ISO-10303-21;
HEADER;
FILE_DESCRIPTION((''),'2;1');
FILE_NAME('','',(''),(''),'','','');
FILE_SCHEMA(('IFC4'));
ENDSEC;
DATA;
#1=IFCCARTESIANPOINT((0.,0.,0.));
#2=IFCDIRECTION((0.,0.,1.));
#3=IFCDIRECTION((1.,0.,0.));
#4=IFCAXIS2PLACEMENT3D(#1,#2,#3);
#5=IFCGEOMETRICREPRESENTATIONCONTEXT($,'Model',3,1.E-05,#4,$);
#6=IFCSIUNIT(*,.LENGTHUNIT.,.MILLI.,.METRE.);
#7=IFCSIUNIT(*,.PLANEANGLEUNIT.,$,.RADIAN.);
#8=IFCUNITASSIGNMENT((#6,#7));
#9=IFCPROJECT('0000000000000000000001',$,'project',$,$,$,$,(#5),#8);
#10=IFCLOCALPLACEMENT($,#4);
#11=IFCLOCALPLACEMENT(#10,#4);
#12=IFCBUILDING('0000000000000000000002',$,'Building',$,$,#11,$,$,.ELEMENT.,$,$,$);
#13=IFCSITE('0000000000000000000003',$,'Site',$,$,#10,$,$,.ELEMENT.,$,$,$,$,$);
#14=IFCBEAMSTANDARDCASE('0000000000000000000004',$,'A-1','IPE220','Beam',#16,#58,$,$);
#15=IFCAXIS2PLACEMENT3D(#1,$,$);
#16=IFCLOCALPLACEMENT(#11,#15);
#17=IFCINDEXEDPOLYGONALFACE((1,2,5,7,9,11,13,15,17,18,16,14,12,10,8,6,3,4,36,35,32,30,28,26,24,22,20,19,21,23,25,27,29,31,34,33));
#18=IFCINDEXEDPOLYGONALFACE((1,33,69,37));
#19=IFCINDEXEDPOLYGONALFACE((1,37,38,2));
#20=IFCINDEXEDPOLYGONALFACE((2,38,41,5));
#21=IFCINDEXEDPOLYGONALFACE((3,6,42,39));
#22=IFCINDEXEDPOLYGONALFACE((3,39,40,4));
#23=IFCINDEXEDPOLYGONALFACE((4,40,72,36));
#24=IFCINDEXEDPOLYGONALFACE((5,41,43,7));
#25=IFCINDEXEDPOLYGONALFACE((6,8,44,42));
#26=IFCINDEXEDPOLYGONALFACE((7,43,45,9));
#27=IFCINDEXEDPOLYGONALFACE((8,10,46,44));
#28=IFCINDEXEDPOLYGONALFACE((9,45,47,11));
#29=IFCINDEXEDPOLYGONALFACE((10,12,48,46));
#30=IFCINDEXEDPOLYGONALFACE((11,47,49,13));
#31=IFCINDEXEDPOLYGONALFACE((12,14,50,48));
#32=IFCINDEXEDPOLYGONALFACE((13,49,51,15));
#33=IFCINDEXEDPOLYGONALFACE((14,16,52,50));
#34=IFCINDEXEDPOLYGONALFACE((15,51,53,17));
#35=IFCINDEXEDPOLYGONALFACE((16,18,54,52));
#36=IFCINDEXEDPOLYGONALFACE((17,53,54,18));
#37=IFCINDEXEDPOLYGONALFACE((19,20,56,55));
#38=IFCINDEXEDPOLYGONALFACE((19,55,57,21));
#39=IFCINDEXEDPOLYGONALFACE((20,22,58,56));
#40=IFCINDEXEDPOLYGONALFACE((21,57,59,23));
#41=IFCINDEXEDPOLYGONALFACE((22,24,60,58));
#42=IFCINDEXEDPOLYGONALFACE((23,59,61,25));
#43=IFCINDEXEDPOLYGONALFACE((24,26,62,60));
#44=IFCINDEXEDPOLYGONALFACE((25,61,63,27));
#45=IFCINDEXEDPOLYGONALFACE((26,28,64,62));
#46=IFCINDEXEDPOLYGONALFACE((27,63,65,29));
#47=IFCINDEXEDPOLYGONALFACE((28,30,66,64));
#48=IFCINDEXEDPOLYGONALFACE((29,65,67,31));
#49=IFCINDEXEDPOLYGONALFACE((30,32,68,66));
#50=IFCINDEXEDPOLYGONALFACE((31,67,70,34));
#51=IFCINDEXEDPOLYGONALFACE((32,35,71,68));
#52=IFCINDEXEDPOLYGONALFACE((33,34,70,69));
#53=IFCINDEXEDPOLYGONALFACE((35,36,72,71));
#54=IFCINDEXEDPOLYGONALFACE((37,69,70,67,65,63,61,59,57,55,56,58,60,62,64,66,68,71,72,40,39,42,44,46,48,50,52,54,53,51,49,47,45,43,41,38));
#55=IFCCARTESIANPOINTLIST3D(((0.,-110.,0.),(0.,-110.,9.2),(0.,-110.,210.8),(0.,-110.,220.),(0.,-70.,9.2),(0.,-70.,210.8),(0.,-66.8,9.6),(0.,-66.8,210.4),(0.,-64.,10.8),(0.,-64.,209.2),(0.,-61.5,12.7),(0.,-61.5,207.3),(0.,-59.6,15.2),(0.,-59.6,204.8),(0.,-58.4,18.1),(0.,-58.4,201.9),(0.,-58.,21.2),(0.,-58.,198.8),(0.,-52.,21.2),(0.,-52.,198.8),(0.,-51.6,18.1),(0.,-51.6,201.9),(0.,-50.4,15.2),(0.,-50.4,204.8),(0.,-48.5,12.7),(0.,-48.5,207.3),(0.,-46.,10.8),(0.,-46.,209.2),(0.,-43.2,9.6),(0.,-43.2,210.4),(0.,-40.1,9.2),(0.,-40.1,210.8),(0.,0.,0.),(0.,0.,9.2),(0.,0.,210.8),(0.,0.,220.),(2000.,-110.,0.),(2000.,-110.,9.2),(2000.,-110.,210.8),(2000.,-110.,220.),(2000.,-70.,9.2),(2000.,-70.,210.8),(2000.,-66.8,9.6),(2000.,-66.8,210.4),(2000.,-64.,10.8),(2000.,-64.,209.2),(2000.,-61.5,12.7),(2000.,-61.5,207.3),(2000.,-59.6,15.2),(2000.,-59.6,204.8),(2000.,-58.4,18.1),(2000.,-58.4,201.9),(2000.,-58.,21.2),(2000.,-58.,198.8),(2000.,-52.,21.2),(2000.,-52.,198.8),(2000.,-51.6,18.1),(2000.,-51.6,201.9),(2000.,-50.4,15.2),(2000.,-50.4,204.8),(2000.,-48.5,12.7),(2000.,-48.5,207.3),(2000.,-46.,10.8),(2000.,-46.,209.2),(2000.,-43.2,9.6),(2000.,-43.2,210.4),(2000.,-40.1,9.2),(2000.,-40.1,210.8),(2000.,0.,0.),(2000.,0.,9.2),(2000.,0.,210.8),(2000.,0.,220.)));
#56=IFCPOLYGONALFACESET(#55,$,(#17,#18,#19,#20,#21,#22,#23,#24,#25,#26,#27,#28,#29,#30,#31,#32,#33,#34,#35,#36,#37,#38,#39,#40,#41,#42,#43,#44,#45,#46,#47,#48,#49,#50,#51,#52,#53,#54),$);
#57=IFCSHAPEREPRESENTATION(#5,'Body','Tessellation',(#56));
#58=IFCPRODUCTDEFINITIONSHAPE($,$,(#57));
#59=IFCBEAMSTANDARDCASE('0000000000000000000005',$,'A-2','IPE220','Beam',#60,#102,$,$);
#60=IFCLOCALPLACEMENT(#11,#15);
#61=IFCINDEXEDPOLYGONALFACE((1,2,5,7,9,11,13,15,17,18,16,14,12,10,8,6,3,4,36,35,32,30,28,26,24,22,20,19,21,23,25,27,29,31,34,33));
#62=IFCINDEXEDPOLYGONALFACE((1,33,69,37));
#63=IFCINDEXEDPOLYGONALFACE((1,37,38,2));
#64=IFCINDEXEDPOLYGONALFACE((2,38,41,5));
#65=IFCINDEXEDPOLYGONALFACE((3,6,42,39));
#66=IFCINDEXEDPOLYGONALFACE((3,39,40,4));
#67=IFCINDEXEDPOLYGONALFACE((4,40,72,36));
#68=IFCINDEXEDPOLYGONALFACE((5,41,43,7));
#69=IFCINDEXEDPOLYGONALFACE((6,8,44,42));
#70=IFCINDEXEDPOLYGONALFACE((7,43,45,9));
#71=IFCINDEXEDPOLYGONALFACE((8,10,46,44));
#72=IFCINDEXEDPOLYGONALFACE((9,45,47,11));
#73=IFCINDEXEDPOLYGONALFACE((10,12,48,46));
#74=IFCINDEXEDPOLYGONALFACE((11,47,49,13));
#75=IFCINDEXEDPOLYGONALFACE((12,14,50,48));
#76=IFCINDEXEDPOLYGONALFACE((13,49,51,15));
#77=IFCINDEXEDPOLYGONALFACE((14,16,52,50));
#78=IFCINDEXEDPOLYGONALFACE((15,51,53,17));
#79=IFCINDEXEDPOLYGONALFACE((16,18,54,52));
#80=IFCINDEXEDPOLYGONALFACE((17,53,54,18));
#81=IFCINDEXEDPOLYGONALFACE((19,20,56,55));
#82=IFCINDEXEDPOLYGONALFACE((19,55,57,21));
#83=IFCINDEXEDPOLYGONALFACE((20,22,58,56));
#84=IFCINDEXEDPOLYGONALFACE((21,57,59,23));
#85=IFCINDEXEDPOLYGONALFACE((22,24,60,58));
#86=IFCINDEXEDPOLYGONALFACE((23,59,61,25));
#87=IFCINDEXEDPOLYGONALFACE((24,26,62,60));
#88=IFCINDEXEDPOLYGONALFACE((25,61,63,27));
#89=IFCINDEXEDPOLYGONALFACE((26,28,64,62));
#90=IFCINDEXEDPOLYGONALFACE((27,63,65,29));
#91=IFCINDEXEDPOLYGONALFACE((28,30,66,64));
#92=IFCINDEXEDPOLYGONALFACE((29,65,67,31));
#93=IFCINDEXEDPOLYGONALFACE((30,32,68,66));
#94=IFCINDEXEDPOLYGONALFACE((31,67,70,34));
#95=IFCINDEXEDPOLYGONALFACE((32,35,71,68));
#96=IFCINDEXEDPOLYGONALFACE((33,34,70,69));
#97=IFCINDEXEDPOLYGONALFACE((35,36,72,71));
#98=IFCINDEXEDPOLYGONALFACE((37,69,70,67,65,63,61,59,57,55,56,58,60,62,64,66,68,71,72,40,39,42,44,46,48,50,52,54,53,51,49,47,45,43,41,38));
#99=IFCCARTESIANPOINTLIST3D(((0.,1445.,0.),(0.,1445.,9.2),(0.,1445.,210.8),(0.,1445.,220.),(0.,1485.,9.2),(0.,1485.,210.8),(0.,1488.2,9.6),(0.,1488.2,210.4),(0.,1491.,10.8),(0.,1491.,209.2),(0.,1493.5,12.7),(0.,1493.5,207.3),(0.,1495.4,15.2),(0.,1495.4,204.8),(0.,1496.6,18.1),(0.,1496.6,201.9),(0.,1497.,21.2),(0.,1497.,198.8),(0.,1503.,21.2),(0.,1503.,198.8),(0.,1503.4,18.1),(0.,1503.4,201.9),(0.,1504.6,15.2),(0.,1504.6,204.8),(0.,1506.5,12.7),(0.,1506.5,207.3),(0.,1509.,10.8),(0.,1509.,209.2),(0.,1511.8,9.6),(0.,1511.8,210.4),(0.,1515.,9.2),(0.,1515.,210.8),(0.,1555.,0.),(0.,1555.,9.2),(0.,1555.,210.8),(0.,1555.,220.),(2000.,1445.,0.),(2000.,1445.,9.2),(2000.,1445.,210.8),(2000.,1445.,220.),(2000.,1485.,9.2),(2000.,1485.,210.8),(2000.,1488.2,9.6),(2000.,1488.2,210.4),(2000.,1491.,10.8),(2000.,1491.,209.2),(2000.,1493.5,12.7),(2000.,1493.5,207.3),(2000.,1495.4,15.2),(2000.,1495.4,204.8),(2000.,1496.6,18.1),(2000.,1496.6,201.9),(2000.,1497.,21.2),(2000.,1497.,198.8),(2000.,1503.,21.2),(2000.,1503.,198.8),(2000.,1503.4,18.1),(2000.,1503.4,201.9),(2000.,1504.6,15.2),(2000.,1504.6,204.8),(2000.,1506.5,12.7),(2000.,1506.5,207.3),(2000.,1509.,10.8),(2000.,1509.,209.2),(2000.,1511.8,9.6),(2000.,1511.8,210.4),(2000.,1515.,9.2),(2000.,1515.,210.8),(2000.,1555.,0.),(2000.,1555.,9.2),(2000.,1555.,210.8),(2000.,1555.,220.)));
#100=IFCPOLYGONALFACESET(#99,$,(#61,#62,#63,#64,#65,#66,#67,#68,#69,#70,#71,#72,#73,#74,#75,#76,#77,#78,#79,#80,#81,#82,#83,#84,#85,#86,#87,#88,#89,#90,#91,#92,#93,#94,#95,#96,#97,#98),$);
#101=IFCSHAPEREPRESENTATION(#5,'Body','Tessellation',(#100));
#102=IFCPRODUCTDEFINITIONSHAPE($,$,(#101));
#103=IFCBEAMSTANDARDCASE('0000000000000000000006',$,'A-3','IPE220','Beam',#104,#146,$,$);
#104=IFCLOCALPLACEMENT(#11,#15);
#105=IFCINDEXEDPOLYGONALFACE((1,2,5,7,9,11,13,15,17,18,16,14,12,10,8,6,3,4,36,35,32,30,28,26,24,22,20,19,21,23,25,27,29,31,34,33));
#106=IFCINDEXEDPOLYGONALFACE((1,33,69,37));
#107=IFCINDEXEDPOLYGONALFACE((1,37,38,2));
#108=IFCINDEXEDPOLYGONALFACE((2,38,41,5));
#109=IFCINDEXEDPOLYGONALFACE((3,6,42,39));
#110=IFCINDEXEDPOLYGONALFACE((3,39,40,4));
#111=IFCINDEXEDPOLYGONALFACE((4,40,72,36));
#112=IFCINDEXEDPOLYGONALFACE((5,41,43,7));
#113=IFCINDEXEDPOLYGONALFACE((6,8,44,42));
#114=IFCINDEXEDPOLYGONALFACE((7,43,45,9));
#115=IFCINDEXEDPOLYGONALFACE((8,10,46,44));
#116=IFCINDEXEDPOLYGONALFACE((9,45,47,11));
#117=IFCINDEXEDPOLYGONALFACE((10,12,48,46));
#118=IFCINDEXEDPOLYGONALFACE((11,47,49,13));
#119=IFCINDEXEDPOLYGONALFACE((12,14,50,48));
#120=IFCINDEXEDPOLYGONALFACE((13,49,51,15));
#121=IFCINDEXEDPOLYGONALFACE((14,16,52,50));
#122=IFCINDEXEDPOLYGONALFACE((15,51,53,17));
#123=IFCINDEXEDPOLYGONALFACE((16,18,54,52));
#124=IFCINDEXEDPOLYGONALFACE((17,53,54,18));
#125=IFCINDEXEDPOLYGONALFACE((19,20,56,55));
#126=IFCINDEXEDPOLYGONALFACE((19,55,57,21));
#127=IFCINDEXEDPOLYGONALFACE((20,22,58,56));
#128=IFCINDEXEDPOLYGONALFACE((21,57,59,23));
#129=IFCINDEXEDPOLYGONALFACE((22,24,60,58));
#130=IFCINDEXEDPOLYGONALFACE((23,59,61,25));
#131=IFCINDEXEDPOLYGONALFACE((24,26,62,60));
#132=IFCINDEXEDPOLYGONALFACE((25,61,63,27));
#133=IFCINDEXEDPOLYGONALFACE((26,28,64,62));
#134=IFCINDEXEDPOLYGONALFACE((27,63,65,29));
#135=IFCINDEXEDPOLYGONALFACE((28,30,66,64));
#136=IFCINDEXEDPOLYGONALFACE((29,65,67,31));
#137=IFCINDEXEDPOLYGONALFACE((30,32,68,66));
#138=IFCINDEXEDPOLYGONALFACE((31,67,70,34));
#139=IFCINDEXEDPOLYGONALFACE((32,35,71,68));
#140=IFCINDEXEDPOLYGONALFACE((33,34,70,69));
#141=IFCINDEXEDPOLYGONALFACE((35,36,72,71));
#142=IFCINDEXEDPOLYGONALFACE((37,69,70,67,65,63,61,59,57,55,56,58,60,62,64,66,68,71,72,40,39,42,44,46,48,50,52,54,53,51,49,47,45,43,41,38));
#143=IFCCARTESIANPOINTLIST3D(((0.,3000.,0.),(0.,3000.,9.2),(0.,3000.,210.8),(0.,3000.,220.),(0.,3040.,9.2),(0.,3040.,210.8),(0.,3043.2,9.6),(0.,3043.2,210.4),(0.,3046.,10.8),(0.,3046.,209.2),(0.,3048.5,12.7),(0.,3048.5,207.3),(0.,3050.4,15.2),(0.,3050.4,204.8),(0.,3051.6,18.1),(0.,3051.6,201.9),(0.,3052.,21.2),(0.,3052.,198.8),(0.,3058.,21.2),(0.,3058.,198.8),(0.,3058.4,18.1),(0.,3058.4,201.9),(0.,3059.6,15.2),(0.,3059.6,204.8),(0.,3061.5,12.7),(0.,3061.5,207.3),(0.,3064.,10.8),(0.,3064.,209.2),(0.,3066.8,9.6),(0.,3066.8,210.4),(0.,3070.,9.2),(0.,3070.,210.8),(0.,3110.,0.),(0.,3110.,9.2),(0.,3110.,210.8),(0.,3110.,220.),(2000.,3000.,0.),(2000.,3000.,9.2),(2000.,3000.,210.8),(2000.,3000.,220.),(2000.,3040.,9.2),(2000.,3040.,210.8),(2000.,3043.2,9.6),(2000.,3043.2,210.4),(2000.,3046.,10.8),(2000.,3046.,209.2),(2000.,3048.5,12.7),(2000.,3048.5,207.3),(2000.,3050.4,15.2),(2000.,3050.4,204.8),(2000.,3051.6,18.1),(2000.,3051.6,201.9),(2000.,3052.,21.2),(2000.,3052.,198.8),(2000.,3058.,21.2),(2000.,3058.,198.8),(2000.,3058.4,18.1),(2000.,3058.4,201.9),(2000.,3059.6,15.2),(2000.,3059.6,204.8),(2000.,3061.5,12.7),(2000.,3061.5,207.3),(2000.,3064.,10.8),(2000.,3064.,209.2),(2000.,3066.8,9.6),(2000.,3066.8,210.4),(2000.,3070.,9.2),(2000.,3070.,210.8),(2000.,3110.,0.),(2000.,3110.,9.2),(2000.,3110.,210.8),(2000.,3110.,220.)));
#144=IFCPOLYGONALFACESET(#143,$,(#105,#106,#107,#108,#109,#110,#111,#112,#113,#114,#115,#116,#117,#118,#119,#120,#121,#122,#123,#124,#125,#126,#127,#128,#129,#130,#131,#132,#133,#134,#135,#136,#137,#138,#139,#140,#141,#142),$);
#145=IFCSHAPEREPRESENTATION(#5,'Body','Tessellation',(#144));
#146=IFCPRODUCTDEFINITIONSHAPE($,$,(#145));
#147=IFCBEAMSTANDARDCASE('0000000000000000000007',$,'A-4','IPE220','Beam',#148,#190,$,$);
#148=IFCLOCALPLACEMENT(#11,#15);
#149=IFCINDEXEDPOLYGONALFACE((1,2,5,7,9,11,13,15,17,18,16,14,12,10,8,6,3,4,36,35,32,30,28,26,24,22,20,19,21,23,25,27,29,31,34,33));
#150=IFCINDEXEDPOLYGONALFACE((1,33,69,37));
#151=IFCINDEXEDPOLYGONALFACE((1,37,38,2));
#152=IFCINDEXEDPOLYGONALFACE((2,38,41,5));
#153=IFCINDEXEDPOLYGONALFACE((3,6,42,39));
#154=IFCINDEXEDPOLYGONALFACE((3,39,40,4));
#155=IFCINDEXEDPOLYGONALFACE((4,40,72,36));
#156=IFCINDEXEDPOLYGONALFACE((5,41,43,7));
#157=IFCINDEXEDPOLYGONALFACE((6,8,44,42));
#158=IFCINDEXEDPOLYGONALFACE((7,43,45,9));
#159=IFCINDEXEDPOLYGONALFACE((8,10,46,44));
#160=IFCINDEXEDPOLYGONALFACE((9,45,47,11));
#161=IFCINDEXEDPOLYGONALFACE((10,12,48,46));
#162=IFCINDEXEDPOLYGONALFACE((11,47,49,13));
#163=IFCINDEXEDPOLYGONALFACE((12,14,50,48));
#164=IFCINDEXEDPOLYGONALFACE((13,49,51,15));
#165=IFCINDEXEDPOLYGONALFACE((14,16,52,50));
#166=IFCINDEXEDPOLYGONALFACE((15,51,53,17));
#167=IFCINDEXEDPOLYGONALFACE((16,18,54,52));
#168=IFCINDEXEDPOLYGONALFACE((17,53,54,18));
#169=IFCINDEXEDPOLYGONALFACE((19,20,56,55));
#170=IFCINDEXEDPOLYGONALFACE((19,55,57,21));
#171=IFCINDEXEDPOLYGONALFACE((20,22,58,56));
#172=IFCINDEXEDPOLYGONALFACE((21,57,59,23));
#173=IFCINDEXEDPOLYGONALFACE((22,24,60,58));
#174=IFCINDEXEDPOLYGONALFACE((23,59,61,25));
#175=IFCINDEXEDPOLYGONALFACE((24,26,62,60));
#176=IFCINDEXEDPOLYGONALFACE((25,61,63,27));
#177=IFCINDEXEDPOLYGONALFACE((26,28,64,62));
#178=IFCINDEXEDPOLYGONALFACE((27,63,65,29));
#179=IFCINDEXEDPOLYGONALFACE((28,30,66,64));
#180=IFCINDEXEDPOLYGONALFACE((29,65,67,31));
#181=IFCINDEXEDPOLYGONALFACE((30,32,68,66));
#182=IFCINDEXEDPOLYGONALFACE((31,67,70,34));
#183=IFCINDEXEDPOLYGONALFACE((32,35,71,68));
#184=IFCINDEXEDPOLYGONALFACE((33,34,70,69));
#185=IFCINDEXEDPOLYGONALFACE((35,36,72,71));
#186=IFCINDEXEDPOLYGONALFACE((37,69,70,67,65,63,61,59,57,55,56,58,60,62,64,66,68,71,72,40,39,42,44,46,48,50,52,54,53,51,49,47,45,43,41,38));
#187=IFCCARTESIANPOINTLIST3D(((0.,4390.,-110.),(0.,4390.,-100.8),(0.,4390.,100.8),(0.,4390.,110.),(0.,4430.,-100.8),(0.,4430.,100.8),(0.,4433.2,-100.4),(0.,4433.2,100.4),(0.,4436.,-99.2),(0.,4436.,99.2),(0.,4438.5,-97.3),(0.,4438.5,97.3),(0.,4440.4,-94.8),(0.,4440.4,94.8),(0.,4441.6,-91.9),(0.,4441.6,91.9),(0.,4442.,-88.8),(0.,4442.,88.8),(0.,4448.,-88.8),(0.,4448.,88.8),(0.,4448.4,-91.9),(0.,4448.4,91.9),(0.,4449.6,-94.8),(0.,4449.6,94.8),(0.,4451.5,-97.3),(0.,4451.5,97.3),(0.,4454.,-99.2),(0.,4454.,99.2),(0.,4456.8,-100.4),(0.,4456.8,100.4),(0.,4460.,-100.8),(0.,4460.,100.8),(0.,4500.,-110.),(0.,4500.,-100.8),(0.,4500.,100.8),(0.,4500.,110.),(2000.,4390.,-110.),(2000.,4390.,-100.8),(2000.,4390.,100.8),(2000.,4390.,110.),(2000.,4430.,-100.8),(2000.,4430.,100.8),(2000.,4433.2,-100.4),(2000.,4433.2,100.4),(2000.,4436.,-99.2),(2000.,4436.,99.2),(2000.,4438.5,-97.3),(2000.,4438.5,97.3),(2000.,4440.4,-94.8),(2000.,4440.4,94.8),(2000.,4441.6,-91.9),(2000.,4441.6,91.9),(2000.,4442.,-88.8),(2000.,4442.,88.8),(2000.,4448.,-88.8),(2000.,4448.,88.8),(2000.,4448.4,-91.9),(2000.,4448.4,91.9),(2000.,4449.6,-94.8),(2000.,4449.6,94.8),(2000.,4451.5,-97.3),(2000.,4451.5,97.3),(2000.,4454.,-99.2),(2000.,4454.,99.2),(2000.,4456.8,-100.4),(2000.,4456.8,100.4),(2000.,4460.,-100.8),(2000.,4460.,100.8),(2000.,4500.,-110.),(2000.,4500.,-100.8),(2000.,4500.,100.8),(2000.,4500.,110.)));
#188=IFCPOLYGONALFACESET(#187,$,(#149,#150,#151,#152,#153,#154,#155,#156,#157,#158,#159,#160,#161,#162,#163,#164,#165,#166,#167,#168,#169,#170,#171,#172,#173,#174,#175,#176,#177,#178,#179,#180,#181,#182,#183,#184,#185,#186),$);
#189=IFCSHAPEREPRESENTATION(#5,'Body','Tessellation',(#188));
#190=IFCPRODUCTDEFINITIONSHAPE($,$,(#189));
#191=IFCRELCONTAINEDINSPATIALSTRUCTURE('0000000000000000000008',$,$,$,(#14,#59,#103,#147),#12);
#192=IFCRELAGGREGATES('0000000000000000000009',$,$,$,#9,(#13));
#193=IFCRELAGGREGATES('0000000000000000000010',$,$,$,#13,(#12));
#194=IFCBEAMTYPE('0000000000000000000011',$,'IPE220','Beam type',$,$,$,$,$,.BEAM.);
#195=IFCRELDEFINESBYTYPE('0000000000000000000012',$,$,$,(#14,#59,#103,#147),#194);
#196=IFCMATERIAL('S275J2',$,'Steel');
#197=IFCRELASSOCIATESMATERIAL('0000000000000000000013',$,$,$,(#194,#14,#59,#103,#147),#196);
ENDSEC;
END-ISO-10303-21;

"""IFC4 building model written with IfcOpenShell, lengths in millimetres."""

from ifc_helpers import new_model, si_unit, frame, origin_with_axes, place, context, project, spatial, i_section, extrude, material, material_profile, profile_set, profile_usage, type_object, element, save


model = new_model("IFC4")

# Units and contexts
model_context = context("Model", 3, precision=1e-05, world=origin_with_axes())
ifc_project = project(units=[si_unit("LENGTHUNIT", "METRE", prefix="MILLI"), si_unit("PLANEANGLEUNIT", "RADIAN")], contexts=[model_context])

# Site, building
site_placement = place(None, origin_with_axes())
site = spatial("IfcSite", under=ifc_project, at=site_placement, Name="Site", CompositionType="ELEMENT")
building_placement = place(site_placement, origin_with_axes())
building = spatial("IfcBuilding", under=site, at=building_placement, Name="Building", CompositionType="ELEMENT")

# Beams
ifc_material_1 = material(Name="S275J2", Category="Steel")
ifc_material_profile_1 = material_profile(ifc_material_1, i_section(OverallWidth=110.0, OverallDepth=220.0, WebThickness=5.9, FlangeThickness=9.2, FilletRadius=12.0), Name="IPE220")
ifc_profile_set_1 = profile_set([ifc_material_profile_1])
ifc_profile_usage_1 = profile_usage(ifc_profile_set_1, cardinal=1)
beam_type_1 = type_object("IfcBeamType", Name="IPE220", Description="Beam type", PredefinedType="BEAM", material=ifc_profile_set_1)
beam_1_placement = place(building_placement, frame((0.0, 0.0, 0.0), z_axis=(1.0, 0.0, 0.0), x_axis=(0.0, 1.0, 0.0)))
element("IfcBeamStandardCase", 1, at=beam_1_placement, inside=building, type_object=beam_type_1, material=ifc_profile_usage_1, Name="A-1", Description="IPE220", ObjectType="Beam", context=model_context, shape_type="SweptSolid", body=[
    extrude(i_section(OverallWidth=110.0, OverallDepth=220.0, WebThickness=5.9, FlangeThickness=9.2, FilletRadius=12.0), frame((-55.0, 110.0, 0.0)), (0.0, 0.0, 1.0), 2000.0),
])
ifc_profile_usage_2 = profile_usage(ifc_profile_set_1, cardinal=2)
beam_2_placement = place(building_placement, frame((0.0, 1500.0, 0.0), z_axis=(1.0, 0.0, 0.0), x_axis=(0.0, 1.0, 0.0)))
element("IfcBeamStandardCase", 2, at=beam_2_placement, inside=building, type_object=beam_type_1, material=ifc_profile_usage_2, Name="A-2", Description="IPE220", ObjectType="Beam", context=model_context, shape_type="SweptSolid", body=[
    extrude(i_section(OverallWidth=110.0, OverallDepth=220.0, WebThickness=5.9, FlangeThickness=9.2, FilletRadius=12.0), frame((0.0, 110.0, 0.0)), (0.0, 0.0, 1.0), 2000.0),
])
ifc_profile_usage_3 = profile_usage(ifc_profile_set_1, cardinal=3)
beam_3_placement = place(building_placement, frame((0.0, 3000.0, 0.0), z_axis=(1.0, 0.0, 0.0), x_axis=(0.0, 1.0, 0.0)))
element("IfcBeamStandardCase", 3, at=beam_3_placement, inside=building, type_object=beam_type_1, material=ifc_profile_usage_3, Name="A-3", Description="IPE220", ObjectType="Beam", context=model_context, shape_type="SweptSolid", body=[
    extrude(i_section(OverallWidth=110.0, OverallDepth=220.0, WebThickness=5.9, FlangeThickness=9.2, FilletRadius=12.0), frame((55.0, 110.0, 0.0)), (0.0, 0.0, 1.0), 2000.0),
])
ifc_profile_usage_4 = profile_usage(ifc_profile_set_1, cardinal=4)
beam_4_placement = place(building_placement, frame((0.0, 4500.0, 0.0), z_axis=(1.0, 0.0, 0.0), x_axis=(0.0, 1.0, 0.0)))
element("IfcBeamStandardCase", 4, at=beam_4_placement, inside=building, type_object=beam_type_1, material=ifc_profile_usage_4, Name="A-4", Description="IPE220", ObjectType="Beam", context=model_context, shape_type="SweptSolid", body=[
    extrude(i_section(OverallWidth=110.0, OverallDepth=220.0, WebThickness=5.9, FlangeThickness=9.2, FilletRadius=12.0), frame((-55.0, 0.0, 0.0)), (0.0, 0.0, 1.0), 2000.0),
])

save(model, "model.ifc")
